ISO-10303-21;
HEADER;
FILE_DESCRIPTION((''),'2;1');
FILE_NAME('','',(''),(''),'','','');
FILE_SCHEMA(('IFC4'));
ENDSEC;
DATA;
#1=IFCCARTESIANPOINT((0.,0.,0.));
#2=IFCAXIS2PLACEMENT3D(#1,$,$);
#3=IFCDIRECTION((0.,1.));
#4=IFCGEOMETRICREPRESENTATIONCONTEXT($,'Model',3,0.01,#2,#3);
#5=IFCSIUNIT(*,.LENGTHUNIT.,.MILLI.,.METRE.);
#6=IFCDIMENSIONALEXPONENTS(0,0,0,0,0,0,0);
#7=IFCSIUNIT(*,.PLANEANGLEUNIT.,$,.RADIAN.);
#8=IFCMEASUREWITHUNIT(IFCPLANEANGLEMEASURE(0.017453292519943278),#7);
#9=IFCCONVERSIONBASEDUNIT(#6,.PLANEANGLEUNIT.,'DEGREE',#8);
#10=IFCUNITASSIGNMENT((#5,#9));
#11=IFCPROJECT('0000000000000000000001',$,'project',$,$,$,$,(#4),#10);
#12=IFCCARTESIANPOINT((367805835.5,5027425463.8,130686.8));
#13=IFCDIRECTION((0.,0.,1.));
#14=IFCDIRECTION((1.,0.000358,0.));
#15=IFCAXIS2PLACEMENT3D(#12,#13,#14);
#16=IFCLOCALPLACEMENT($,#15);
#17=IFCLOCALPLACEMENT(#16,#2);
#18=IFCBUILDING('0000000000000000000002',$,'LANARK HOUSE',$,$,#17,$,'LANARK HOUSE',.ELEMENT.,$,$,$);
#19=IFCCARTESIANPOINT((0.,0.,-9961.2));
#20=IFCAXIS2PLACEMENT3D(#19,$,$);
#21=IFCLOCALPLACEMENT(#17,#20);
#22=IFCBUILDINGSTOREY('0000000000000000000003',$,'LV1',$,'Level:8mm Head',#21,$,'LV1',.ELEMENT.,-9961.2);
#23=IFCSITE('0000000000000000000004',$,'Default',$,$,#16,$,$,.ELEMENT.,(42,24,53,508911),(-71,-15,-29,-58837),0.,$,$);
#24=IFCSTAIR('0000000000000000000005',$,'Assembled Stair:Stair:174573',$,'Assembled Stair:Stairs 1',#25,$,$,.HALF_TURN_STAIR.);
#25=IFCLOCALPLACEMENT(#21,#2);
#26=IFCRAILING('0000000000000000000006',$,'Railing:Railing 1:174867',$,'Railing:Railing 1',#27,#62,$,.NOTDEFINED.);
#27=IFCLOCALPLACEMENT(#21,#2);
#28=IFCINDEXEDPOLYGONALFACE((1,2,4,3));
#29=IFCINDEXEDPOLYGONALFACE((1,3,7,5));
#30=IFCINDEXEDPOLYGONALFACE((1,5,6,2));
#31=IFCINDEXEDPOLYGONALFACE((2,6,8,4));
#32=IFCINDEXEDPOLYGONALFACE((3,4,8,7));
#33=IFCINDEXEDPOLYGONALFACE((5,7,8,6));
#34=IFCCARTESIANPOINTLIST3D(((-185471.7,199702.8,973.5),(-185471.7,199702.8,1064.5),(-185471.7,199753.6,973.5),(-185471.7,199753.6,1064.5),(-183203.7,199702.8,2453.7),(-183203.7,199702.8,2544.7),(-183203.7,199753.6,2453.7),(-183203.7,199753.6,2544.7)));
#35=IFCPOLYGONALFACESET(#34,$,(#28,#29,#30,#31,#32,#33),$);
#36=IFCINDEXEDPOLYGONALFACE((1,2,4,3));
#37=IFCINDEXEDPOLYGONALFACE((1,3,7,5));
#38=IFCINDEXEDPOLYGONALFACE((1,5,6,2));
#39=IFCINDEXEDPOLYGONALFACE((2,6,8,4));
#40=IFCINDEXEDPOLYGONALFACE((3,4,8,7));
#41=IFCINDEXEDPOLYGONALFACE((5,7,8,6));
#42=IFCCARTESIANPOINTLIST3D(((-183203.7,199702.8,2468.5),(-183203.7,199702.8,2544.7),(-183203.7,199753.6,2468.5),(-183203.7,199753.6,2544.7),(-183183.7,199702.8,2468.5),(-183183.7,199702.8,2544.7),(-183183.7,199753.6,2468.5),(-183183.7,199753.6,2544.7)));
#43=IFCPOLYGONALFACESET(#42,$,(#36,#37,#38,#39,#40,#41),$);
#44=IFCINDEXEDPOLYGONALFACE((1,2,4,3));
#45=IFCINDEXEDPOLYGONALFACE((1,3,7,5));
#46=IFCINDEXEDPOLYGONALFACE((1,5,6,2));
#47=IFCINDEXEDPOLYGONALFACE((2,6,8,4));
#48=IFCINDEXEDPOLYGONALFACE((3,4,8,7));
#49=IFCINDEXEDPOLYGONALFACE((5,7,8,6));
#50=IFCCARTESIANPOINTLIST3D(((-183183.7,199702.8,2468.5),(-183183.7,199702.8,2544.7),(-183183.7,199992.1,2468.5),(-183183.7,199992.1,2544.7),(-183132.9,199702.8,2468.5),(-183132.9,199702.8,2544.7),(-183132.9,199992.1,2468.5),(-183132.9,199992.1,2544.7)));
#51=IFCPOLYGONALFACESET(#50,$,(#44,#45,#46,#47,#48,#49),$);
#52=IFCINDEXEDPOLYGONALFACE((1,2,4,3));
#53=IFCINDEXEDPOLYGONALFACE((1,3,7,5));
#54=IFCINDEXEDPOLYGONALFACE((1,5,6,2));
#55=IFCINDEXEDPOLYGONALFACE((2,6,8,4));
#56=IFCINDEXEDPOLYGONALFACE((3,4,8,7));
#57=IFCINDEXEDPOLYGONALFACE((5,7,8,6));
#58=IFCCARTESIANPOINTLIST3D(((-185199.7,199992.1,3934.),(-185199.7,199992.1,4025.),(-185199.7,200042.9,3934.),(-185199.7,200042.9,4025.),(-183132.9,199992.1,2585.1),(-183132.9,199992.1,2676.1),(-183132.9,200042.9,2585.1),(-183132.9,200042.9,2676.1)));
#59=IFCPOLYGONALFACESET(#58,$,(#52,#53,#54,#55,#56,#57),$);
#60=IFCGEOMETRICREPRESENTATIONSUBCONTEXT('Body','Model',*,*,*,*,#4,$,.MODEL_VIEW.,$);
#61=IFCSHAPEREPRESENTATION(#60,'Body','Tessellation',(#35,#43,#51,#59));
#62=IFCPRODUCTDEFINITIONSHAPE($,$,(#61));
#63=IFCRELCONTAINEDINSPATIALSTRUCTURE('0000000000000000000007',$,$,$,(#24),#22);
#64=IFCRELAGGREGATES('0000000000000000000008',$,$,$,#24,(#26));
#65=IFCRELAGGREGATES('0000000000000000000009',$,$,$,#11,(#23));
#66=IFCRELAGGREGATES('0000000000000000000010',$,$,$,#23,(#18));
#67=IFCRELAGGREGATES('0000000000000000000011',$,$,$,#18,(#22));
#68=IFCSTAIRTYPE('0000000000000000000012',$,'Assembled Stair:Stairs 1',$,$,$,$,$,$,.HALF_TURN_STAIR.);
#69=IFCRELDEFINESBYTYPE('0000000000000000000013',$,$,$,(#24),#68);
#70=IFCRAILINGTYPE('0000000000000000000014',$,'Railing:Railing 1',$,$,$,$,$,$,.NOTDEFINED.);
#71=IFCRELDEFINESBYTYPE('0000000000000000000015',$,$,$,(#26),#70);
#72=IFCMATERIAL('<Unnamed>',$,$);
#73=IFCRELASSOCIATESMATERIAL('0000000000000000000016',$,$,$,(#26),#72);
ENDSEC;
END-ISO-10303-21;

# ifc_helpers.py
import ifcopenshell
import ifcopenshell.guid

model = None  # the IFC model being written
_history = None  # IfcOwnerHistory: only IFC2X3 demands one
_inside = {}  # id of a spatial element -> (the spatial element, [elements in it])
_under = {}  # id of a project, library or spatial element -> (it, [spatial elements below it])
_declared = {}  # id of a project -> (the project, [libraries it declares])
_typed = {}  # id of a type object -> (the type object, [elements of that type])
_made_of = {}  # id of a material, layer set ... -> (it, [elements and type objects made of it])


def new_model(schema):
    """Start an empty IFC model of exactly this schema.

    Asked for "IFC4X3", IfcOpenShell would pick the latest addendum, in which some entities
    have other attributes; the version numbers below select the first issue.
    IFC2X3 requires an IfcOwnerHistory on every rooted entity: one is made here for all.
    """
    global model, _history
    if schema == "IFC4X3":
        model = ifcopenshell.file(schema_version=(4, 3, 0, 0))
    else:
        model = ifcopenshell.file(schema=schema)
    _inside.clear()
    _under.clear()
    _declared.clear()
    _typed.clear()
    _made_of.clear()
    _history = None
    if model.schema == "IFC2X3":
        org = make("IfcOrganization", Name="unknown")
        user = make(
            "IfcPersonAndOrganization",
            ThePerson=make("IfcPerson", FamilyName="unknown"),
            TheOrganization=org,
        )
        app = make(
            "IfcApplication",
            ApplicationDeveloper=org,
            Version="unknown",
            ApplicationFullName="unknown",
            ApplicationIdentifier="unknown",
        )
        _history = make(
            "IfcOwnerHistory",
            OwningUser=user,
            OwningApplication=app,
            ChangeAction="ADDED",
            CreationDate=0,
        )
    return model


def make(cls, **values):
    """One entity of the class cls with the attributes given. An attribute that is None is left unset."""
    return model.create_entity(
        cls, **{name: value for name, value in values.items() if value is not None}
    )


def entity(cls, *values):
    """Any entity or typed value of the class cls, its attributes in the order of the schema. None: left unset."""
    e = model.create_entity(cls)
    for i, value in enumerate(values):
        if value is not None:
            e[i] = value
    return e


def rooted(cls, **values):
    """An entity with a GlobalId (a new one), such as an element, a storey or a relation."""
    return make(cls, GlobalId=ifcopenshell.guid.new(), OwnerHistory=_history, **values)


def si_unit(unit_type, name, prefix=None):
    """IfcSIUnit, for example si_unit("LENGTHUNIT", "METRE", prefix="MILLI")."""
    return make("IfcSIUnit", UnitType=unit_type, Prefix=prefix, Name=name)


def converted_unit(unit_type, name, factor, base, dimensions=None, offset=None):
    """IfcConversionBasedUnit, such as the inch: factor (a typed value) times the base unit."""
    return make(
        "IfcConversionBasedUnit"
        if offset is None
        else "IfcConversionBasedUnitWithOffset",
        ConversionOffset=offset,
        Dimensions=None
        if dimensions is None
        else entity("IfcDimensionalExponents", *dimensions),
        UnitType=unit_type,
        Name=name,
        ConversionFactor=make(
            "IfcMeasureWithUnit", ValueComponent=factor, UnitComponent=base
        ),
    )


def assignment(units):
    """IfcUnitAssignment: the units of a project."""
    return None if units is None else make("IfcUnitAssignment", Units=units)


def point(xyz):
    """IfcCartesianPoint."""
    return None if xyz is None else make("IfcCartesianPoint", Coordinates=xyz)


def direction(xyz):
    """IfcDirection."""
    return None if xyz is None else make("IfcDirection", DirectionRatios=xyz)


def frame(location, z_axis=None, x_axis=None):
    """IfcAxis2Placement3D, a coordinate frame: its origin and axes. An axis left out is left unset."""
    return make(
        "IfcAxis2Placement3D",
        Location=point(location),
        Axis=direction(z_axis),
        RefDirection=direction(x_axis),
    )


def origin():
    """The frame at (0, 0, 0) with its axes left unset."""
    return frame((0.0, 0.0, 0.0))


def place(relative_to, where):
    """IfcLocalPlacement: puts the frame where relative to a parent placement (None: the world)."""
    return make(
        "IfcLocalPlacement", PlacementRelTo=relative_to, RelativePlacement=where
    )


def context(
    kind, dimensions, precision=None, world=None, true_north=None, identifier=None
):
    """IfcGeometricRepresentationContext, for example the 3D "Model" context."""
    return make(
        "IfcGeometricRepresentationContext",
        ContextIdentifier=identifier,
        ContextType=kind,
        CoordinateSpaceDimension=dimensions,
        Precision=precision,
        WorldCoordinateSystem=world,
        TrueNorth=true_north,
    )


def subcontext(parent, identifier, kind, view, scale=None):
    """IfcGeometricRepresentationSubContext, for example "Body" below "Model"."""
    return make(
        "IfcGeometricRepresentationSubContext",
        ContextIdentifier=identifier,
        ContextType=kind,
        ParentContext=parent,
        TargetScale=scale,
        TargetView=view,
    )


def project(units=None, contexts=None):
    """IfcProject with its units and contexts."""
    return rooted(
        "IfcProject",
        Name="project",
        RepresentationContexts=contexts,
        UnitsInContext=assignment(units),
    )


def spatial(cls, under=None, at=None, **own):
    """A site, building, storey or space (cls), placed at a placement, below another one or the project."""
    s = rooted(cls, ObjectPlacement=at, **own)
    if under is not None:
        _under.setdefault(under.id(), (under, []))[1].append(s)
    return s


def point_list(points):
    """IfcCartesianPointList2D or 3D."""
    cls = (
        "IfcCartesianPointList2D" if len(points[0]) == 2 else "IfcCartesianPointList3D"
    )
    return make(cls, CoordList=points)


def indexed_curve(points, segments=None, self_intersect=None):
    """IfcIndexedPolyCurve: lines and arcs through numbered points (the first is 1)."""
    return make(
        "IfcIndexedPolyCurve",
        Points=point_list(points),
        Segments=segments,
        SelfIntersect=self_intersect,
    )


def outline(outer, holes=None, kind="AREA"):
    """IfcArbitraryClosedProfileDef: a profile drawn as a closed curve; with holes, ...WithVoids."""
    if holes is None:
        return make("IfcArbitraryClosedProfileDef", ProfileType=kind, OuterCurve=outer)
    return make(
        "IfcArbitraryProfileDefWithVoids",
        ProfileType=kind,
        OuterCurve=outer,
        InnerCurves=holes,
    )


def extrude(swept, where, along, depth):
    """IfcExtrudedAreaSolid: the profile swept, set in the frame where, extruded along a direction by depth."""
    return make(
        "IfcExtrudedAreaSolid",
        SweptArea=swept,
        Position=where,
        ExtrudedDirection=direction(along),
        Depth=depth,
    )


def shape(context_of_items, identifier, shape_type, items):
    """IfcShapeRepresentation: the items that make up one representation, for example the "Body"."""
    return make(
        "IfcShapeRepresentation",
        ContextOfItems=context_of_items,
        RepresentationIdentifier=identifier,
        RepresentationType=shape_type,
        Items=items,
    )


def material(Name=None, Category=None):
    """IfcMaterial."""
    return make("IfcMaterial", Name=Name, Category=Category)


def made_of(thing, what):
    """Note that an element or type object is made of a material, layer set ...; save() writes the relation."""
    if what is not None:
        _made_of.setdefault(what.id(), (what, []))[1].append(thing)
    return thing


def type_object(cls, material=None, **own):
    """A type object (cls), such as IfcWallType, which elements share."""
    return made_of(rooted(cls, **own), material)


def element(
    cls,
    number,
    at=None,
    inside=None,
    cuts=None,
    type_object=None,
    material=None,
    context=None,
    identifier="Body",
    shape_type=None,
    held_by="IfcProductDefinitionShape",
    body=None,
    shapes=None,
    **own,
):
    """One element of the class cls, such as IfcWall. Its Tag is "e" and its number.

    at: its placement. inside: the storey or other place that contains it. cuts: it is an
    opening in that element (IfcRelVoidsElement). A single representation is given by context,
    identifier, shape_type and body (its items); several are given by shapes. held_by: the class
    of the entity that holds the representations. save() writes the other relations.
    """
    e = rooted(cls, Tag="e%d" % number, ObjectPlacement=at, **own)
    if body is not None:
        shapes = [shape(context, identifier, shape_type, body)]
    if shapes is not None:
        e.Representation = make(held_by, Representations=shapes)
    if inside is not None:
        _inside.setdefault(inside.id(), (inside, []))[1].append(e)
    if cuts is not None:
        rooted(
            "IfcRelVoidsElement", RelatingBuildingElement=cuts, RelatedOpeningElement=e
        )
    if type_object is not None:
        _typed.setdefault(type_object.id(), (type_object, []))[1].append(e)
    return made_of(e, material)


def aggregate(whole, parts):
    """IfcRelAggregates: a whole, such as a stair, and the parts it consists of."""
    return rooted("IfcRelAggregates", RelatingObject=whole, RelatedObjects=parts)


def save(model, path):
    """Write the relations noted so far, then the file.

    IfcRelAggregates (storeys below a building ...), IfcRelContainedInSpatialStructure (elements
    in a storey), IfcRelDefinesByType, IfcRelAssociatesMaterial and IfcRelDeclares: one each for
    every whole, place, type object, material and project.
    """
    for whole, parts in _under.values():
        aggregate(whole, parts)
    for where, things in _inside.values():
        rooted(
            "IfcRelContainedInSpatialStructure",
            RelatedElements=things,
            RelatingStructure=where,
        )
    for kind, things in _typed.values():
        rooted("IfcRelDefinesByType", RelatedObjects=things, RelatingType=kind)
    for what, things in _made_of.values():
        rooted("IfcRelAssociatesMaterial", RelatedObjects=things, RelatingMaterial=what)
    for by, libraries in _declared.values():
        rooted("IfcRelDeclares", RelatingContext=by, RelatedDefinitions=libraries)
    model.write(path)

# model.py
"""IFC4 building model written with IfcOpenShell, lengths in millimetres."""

from ifc_helpers import new_model, entity, si_unit, converted_unit, direction, frame, origin, place, context, subcontext, project, spatial, indexed_curve, outline, extrude, material, type_object, element, aggregate, save


model = new_model("IFC4")

# Units and contexts
model_context = context("Model", 3, precision=0.01, world=origin(), true_north=direction((0.0, 1.0)))
body_context = subcontext(model_context, "Body", "Model", "MODEL_VIEW")
ifc_project = project(units=[si_unit("LENGTHUNIT", "METRE", prefix="MILLI"), converted_unit("PLANEANGLEUNIT", "DEGREE", entity("IfcPlaneAngleMeasure", 0.017453292519943278), si_unit("PLANEANGLEUNIT", "RADIAN"), dimensions=[0, 0, 0, 0, 0, 0, 0])], contexts=[model_context])

# Site, building, storey
site_placement = place(None, frame((367805835.5, 5027425463.8, 130686.8), z_axis=(0.0, 0.0, 1.0), x_axis=(1.0, 0.000358, 0.0)))
site = spatial("IfcSite", under=ifc_project, at=site_placement, Name="Default", CompositionType="ELEMENT", RefLatitude=(42, 24, 53, 508911), RefLongitude=(-71, -15, -29, -58837), RefElevation=0.0)
building_placement = place(site_placement, origin())
building = spatial("IfcBuilding", under=site, at=building_placement, Name="LANARK HOUSE", LongName="LANARK HOUSE", CompositionType="ELEMENT")
storey_placement = place(building_placement, frame((0.0, 0.0, -9961.2)))
storey = spatial("IfcBuildingStorey", under=building, at=storey_placement, Name="LV1", ObjectType="Level:8mm Head", LongName="LV1", CompositionType="ELEMENT", Elevation=-9961.2)

# Stair
stair_type = type_object("IfcStairType", Name="Assembled Stair:Stairs 1", PredefinedType="HALF_TURN_STAIR")
stair_placement = place(storey_placement, origin())
stair = element("IfcStair", 1, at=stair_placement, inside=storey, type_object=stair_type, Name="Assembled Stair:Stair:174573", ObjectType="Assembled Stair:Stairs 1", PredefinedType="HALF_TURN_STAIR")
ifc_material_1 = material(Name="<Unnamed>")

# Railing
railing_type = type_object("IfcRailingType", Name="Railing:Railing 1", PredefinedType="NOTDEFINED")
railing_1_placement = place(stair_placement, frame((-185471.7, 199702.8, 973.5)))
railing_1 = element("IfcRailing", 2, at=railing_1_placement, type_object=railing_type, material=ifc_material_1, Name="Railing:Railing 1:174867", ObjectType="Railing:Railing 1", PredefinedType="NOTDEFINED", context=body_context, shape_type="SweptSolid", body=[
    extrude(outline(indexed_curve([(-1329.3, -38.1), (1379.0, -38.1), (1329.3, 38.1), (-1379.0, 38.1), (-1329.3, -38.1)], self_intersect=False)), frame((1134.0, 0.0, 785.6), z_axis=(0.0, 1.0, 0.0), x_axis=(0.837419, 0.0, 0.546561)), (0.0, 0.0, 1.0), 50.8),
    extrude(outline(indexed_curve([(-10.0, -25.4), (10.0, -25.4), (10.0, 25.4), (-10.0, 25.4), (-10.0, -25.4)], self_intersect=False)), frame((2278.0, 25.4, 1495.1)), (0.0, 0.0, 1.0), 76.2),
    extrude(outline(indexed_curve([(-144.6, -25.4), (144.6, -25.4), (144.6, 25.4), (-144.6, 25.4), (-144.6, -25.4)], self_intersect=False)), frame((2313.4, 144.6, 1495.1), z_axis=(0.0, 0.0, 1.0), x_axis=(0.0, 1.0, 0.0)), (0.0, 0.0, 1.0), 76.2),
    extrude(outline(indexed_curve([(-1258.9, -38.1), (1209.2, -38.1), (1258.9, 38.1), (-1209.2, 38.1), (-1258.9, -38.1)], self_intersect=False)), frame((1305.4, 289.2, 2331.6), z_axis=(0.0, 1.0, 0.0), x_axis=(-0.837419, 0.0, 0.546561)), (0.0, 0.0, 1.0), 50.8),
])
aggregate(stair, [railing_1])

save(model, "model.ifc")
